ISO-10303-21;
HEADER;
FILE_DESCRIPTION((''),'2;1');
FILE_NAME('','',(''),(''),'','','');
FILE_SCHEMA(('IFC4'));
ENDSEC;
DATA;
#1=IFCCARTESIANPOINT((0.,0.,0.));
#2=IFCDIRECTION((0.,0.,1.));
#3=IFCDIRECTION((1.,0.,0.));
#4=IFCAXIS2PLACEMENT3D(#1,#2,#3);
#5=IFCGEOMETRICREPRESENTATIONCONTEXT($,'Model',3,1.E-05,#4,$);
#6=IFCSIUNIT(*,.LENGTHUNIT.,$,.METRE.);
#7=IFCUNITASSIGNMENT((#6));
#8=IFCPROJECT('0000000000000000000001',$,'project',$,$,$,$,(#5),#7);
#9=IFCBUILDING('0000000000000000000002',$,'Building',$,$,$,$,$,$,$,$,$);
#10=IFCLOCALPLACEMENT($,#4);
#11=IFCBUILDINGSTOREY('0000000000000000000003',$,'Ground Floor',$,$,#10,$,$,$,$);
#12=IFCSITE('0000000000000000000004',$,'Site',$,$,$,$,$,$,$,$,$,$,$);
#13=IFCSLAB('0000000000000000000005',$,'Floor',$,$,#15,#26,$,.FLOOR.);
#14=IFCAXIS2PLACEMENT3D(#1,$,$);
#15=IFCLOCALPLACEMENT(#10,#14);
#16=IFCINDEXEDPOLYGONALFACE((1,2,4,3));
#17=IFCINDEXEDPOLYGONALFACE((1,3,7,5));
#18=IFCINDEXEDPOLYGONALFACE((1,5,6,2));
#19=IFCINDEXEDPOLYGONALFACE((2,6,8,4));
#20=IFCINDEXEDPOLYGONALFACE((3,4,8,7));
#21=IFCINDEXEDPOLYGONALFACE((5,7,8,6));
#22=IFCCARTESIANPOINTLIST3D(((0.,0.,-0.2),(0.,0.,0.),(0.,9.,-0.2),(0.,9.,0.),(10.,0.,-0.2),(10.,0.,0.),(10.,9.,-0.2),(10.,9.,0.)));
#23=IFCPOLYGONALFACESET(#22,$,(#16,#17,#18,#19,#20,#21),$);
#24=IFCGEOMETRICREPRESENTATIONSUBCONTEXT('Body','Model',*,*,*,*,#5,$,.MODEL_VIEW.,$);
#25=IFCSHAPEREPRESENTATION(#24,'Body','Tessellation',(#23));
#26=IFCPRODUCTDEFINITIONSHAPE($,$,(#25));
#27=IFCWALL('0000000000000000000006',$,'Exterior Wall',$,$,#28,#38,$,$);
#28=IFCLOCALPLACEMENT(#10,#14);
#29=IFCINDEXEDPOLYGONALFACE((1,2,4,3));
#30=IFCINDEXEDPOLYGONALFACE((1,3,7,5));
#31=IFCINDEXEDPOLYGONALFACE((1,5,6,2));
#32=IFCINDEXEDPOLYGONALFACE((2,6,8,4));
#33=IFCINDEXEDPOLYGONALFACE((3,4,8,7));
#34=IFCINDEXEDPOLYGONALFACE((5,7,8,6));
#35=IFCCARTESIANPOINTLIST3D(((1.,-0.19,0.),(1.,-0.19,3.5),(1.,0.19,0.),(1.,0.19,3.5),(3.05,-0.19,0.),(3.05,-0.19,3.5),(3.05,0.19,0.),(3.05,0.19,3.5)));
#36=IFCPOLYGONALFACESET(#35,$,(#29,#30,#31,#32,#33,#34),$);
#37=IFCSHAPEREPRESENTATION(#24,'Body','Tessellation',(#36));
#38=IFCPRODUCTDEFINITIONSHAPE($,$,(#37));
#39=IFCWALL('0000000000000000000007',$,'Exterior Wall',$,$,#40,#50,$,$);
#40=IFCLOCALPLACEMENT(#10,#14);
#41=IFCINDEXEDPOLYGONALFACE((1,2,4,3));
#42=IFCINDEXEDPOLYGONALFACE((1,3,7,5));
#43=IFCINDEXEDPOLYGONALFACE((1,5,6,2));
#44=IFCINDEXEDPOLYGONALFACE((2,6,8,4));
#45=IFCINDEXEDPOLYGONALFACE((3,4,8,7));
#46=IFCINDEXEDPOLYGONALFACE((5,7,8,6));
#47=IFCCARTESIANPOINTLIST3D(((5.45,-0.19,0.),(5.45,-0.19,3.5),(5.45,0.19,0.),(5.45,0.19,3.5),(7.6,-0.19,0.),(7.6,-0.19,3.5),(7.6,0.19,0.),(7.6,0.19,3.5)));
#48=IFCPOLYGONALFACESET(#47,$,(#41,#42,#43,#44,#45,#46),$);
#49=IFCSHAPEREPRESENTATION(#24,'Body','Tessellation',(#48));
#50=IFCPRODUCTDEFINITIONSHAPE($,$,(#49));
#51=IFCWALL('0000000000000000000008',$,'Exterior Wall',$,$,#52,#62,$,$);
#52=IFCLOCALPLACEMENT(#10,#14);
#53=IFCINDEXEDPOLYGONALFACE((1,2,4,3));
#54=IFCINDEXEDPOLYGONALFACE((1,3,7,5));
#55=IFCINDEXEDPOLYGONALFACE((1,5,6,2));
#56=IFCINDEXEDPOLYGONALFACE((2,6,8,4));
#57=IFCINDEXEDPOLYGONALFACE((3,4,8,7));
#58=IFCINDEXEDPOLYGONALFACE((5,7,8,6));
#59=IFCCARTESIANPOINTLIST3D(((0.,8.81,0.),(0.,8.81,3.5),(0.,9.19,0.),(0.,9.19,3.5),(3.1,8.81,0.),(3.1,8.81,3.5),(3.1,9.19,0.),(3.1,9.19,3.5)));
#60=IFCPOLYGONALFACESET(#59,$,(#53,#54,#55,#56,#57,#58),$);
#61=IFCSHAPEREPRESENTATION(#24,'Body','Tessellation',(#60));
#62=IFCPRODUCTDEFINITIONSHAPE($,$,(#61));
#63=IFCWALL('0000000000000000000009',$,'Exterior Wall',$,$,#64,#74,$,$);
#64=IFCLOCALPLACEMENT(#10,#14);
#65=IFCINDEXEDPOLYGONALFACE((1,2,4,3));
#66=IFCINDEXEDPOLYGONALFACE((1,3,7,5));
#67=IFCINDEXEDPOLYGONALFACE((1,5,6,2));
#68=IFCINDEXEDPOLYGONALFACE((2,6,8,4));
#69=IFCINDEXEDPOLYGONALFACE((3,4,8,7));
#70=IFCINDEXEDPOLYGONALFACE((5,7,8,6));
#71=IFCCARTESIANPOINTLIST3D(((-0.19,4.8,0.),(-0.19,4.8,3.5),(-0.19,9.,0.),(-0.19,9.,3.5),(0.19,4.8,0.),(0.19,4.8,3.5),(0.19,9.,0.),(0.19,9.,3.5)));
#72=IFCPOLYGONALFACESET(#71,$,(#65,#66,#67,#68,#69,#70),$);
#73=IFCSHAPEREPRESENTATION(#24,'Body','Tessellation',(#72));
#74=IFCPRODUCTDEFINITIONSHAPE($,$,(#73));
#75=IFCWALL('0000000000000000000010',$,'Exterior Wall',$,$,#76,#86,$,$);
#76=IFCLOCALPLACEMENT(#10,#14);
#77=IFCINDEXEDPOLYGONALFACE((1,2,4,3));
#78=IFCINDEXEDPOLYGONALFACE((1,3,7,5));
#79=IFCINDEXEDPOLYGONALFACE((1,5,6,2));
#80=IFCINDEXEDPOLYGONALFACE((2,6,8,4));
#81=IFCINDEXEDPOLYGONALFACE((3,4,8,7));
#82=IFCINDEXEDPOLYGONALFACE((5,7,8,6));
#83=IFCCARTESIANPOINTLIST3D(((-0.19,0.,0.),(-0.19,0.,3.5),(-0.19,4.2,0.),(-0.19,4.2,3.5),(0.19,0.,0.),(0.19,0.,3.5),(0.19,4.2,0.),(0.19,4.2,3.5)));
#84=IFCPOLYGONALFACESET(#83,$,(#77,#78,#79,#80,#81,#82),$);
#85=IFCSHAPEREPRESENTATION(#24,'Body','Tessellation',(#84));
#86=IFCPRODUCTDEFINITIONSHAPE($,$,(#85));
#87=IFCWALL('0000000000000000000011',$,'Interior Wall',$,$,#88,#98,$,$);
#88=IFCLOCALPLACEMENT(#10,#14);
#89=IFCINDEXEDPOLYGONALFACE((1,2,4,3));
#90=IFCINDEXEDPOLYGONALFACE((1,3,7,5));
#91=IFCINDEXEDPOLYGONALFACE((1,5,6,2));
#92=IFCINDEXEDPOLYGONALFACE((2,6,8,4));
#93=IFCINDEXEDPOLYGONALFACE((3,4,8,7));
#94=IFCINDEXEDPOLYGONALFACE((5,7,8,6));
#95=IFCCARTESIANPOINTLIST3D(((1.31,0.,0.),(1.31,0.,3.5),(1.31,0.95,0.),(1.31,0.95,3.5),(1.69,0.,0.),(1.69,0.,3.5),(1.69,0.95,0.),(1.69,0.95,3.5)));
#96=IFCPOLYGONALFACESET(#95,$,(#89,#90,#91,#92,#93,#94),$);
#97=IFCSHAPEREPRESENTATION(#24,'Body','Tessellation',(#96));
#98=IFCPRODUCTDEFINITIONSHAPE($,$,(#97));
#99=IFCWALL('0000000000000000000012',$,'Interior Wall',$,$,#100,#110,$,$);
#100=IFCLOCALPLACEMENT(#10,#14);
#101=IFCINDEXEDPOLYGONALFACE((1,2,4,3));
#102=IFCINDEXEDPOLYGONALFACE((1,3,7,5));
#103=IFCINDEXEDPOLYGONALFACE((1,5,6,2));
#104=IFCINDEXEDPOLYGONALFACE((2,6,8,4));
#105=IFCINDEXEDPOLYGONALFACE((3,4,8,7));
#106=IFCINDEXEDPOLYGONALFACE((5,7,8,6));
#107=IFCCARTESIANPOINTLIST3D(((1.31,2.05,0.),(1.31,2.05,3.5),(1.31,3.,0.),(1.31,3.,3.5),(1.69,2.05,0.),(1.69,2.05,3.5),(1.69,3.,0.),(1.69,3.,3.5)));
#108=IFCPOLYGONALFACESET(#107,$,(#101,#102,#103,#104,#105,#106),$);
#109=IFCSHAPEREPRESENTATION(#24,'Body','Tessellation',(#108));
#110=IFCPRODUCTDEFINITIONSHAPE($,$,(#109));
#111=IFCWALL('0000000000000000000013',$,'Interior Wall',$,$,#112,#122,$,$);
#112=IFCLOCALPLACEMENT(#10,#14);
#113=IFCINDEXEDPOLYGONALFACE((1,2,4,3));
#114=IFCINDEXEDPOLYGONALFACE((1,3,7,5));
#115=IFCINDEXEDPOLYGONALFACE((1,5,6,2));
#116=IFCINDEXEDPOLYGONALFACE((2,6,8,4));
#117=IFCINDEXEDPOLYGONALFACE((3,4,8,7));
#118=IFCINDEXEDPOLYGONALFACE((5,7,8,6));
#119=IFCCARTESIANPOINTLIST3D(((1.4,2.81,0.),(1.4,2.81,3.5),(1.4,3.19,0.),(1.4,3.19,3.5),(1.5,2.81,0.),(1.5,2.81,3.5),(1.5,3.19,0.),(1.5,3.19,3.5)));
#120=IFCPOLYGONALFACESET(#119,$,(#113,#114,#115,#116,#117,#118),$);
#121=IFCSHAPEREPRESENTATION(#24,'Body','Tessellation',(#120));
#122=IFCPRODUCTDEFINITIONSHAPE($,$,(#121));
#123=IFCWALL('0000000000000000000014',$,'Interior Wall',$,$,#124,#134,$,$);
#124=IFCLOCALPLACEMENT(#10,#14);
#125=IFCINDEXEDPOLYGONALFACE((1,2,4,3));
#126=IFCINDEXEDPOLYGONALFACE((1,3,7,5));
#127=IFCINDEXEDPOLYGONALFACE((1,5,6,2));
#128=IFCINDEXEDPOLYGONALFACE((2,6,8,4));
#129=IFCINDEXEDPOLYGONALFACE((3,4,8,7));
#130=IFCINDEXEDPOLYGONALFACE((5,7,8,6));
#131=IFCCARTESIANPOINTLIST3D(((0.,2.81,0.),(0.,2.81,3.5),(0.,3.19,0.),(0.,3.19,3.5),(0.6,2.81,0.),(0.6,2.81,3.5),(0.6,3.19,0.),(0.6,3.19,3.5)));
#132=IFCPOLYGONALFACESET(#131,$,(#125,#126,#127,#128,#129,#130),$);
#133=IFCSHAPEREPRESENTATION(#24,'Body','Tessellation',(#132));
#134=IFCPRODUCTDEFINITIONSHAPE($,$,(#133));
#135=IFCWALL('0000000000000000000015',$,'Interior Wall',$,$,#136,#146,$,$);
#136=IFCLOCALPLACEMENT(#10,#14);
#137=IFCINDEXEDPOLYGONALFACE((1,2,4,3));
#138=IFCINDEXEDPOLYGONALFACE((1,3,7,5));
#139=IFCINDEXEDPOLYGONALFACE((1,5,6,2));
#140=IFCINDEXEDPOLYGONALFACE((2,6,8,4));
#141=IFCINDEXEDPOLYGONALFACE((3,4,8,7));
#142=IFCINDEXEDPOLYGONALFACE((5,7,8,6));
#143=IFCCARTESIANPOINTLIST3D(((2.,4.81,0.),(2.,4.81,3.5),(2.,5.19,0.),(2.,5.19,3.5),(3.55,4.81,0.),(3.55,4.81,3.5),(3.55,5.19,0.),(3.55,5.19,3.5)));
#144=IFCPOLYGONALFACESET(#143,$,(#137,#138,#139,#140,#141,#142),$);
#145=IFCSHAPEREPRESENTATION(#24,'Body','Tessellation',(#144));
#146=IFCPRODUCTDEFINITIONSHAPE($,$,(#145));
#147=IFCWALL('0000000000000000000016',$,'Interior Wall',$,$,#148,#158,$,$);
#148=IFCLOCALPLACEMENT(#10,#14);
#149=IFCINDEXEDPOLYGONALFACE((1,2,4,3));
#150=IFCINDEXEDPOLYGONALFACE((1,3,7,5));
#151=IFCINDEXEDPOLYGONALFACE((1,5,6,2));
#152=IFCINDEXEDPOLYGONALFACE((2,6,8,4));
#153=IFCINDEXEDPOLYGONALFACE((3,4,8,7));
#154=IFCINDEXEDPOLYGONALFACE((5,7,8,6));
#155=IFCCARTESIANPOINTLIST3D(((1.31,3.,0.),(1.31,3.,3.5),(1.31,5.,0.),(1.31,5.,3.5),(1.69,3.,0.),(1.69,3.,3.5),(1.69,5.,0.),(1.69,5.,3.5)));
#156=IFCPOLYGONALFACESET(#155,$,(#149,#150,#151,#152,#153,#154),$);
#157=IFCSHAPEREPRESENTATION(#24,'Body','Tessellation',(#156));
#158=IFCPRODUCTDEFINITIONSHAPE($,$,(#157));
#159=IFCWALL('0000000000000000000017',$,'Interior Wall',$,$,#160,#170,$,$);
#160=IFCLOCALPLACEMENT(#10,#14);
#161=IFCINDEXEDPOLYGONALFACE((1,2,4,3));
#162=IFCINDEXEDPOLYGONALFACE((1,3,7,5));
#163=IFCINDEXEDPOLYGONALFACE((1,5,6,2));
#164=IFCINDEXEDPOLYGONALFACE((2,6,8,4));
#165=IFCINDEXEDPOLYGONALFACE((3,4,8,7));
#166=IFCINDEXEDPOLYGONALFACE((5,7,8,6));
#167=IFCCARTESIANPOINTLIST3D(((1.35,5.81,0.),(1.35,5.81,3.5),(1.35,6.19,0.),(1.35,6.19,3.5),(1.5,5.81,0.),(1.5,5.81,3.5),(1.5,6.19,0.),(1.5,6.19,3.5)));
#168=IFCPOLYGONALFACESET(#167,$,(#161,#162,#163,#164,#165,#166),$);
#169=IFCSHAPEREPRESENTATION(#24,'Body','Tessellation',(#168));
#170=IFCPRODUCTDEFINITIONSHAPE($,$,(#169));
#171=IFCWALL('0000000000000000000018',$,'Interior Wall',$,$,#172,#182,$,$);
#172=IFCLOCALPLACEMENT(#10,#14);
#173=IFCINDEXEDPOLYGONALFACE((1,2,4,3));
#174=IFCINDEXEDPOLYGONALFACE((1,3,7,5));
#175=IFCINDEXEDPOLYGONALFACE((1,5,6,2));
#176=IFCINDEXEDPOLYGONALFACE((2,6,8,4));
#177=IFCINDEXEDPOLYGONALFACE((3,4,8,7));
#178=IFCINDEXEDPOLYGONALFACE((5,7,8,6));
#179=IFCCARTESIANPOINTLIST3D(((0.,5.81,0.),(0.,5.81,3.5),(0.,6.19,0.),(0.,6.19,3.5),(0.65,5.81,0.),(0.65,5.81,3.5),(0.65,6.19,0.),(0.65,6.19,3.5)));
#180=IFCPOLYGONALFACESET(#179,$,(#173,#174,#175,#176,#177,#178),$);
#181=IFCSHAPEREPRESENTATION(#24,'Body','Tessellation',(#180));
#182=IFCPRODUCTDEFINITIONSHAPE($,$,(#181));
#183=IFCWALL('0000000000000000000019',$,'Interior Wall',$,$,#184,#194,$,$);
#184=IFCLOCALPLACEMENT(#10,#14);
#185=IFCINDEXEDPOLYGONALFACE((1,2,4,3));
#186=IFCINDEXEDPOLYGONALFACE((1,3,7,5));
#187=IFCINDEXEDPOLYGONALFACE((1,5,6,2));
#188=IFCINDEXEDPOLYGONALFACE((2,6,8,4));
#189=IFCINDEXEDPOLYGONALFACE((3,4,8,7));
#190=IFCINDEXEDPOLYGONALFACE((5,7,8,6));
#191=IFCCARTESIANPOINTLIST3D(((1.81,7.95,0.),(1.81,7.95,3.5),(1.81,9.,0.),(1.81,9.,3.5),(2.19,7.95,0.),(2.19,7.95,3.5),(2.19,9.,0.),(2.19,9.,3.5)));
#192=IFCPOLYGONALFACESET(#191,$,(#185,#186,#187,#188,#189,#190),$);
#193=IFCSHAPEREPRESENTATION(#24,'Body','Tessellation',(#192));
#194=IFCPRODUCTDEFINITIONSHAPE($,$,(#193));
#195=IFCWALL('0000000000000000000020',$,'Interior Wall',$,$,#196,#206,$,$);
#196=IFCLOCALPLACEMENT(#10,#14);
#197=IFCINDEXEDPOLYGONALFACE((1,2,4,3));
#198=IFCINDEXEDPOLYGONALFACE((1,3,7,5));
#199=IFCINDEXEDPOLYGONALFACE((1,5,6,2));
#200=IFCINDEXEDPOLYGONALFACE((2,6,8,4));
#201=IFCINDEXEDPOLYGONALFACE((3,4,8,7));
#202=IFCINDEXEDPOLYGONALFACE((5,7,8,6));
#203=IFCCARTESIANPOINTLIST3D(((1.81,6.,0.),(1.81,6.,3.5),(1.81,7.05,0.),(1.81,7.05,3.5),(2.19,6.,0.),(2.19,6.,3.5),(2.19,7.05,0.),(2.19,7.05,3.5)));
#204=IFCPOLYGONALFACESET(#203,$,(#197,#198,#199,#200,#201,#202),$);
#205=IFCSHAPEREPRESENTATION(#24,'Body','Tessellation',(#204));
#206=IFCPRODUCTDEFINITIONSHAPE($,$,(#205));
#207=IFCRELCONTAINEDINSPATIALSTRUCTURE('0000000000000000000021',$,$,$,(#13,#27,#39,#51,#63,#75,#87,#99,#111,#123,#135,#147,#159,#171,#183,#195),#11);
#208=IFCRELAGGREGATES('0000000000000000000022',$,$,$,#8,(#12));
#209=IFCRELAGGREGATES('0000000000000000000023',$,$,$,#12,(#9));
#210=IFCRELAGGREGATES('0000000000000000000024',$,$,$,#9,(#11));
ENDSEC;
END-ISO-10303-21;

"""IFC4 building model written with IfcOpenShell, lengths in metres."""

from ifc_helpers import new_model, si_unit, frame, origin_with_axes, place, context, subcontext, project, spatial, indexed_curve, outline, extrude, element, save


model = new_model("IFC4")

# Units and contexts
model_context = context("Model", 3, precision=1e-05, world=origin_with_axes())
body_context = subcontext(model_context, "Body", "Model", "MODEL_VIEW")
ifc_project = project(units=[si_unit("LENGTHUNIT", "METRE")], contexts=[model_context])

# Site, building, storey
site = spatial("IfcSite", under=ifc_project, Name="Site")
building = spatial("IfcBuilding", under=site, Name="Building")
storey_placement = place(None, origin_with_axes())
storey = spatial("IfcBuildingStorey", under=building, at=storey_placement, Name="Ground Floor")

# Slab
slab_placement = place(storey_placement, frame((0.0, 0.0, -0.2), z_axis=(0.0, 0.0, 1.0), x_axis=(1.0, 0.0, 0.0)))
element("IfcSlab", 1, at=slab_placement, inside=storey, Name="Floor", PredefinedType="FLOOR", context=body_context, shape_type="SweptSolid", body=[
    extrude(outline(indexed_curve([(0.0, 0.0), (10.0, 0.0), (10.0, 9.0), (0.0, 9.0)])), None, (0.0, 0.0, 1.0), 0.2),
])

# Walls
wall_1_placement = place(storey_placement, frame((1.0, 0.0, 0.0), z_axis=(0.0, 0.0, 1.0), x_axis=(1.0, 0.0, 0.0)))
element("IfcWall", 2, at=wall_1_placement, inside=storey, Name="Exterior Wall", context=body_context, shape_type="SweptSolid", body=[
    extrude(outline(indexed_curve([(0.0, 0.0), (0.0, 0.38), (2.05, 0.38), (2.05, 0.0), (0.0, 0.0)], self_intersect=False)), frame((0.0, -0.19, 0.0), z_axis=(0.0, 0.0, 1.0), x_axis=(1.0, 0.0, 0.0)), (0.0, 0.0, 1.0), 3.5),
])
wall_2_placement = place(storey_placement, frame((5.45, 0.0, 0.0), z_axis=(0.0, 0.0, 1.0), x_axis=(1.0, 0.0, 0.0)))
element("IfcWall", 3, at=wall_2_placement, inside=storey, Name="Exterior Wall", context=body_context, shape_type="SweptSolid", body=[
    extrude(outline(indexed_curve([(0.0, 0.0), (0.0, 0.38), (2.15, 0.38), (2.15, 0.0), (0.0, 0.0)], self_intersect=False)), frame((0.0, -0.19, 0.0), z_axis=(0.0, 0.0, 1.0), x_axis=(1.0, 0.0, 0.0)), (0.0, 0.0, 1.0), 3.5),
])
wall_3_placement = place(storey_placement, frame((3.1, 9.0, 0.0), z_axis=(0.0, 0.0, 1.0), x_axis=(-1.0, 0.0, 0.0)))
element("IfcWall", 4, at=wall_3_placement, inside=storey, Name="Exterior Wall", context=body_context, shape_type="SweptSolid", body=[
    extrude(outline(indexed_curve([(0.0, 0.0), (0.0, 0.38), (3.1, 0.38), (3.1, 0.0), (0.0, 0.0)], self_intersect=False)), frame((0.0, -0.19, 0.0), z_axis=(0.0, 0.0, 1.0), x_axis=(1.0, 0.0, 0.0)), (0.0, 0.0, 1.0), 3.5),
])
for number, where, z_axis, x_axis, name in (
    (5, (0.0, 9.0, 0.0), (0.0, 0.0, 1.0), (0.0, -1.0, 0.0), "Exterior Wall"),
    (6, (0.0, 4.2, 0.0), (0.0, 0.0, 1.0), (0.0, -1.0, 0.0), "Exterior Wall"),
):
    element("IfcWall", number, at=place(storey_placement, frame(where, z_axis=z_axis, x_axis=x_axis)), inside=storey, Name=name, context=body_context, shape_type="SweptSolid", body=[
        extrude(outline(indexed_curve([(0.0, 0.0), (0.0, 0.38), (4.2, 0.38), (4.2, 0.0), (0.0, 0.0)], self_intersect=False)), frame((0.0, -0.19, 0.0), z_axis=(0.0, 0.0, 1.0), x_axis=(1.0, 0.0, 0.0)), (0.0, 0.0, 1.0), 3.5),
    ])
wall_4_placement = place(storey_placement, frame((1.5, 0.0, 0.0), z_axis=(0.0, 0.0, 1.0), x_axis=(0.0, 1.0, 0.0)))
element("IfcWall", 7, at=wall_4_placement, inside=storey, Name="Interior Wall", context=body_context, shape_type="SweptSolid", body=[
    extrude(outline(indexed_curve([(0.0, 0.0), (0.0, 0.38), (0.95, 0.38), (0.95, 0.0), (0.0, 0.0)], self_intersect=False)), frame((0.0, -0.19, 0.0), z_axis=(0.0, 0.0, 1.0), x_axis=(1.0, 0.0, 0.0)), (0.0, 0.0, 1.0), 3.5),
])
wall_5_placement = place(storey_placement, frame((1.5, 2.05, 0.0), z_axis=(0.0, 0.0, 1.0), x_axis=(0.0, 1.0, 0.0)))
element("IfcWall", 8, at=wall_5_placement, inside=storey, Name="Interior Wall", context=body_context, shape_type="SweptSolid", body=[
    extrude(outline(indexed_curve([(0.0, 0.0), (0.0, 0.38), (0.95, 0.38), (0.95, 0.0), (0.0, 0.0)], self_intersect=False)), frame((0.0, -0.19, 0.0), z_axis=(0.0, 0.0, 1.0), x_axis=(1.0, 0.0, 0.0)), (0.0, 0.0, 1.0), 3.5),
])
wall_6_placement = place(storey_placement, frame((1.5, 3.0, 0.0), z_axis=(0.0, 0.0, 1.0), x_axis=(-1.0, 0.0, 0.0)))
element("IfcWall", 9, at=wall_6_placement, inside=storey, Name="Interior Wall", context=body_context, shape_type="SweptSolid", body=[
    extrude(outline(indexed_curve([(0.0, 0.0), (0.0, 0.38), (0.1, 0.38), (0.1, 0.0), (0.0, 0.0)], self_intersect=False)), frame((0.0, -0.19, 0.0), z_axis=(0.0, 0.0, 1.0), x_axis=(1.0, 0.0, 0.0)), (0.0, 0.0, 1.0), 3.5),
])
wall_7_placement = place(storey_placement, frame((0.6, 3.0, 0.0), z_axis=(0.0, 0.0, 1.0), x_axis=(-1.0, 0.0, 0.0)))
element("IfcWall", 10, at=wall_7_placement, inside=storey, Name="Interior Wall", context=body_context, shape_type="SweptSolid", body=[
    extrude(outline(indexed_curve([(0.0, 0.0), (0.0, 0.38), (0.6, 0.38), (0.6, 0.0), (0.0, 0.0)], self_intersect=False)), frame((0.0, -0.19, 0.0), z_axis=(0.0, 0.0, 1.0), x_axis=(1.0, 0.0, 0.0)), (0.0, 0.0, 1.0), 3.5),
])
wall_8_placement = place(storey_placement, frame((3.55, 5.0, 0.0), z_axis=(0.0, 0.0, 1.0), x_axis=(-1.0, 0.0, 0.0)))
element("IfcWall", 11, at=wall_8_placement, inside=storey, Name="Interior Wall", context=body_context, shape_type="SweptSolid", body=[
    extrude(outline(indexed_curve([(0.0, 0.0), (0.0, 0.38), (1.55, 0.38), (1.55, 0.0), (0.0, 0.0)], self_intersect=False)), frame((0.0, -0.19, 0.0), z_axis=(0.0, 0.0, 1.0), x_axis=(1.0, 0.0, 0.0)), (0.0, 0.0, 1.0), 3.5),
])
wall_9_placement = place(storey_placement, frame((1.5, 5.0, 0.0), z_axis=(0.0, 0.0, 1.0), x_axis=(0.0, -1.0, 0.0)))
element("IfcWall", 12, at=wall_9_placement, inside=storey, Name="Interior Wall", context=body_context, shape_type="SweptSolid", body=[
    extrude(outline(indexed_curve([(0.0, 0.0), (0.0, 0.38), (2.0, 0.38), (2.0, 0.0), (0.0, 0.0)], self_intersect=False)), frame((0.0, -0.19, 0.0), z_axis=(0.0, 0.0, 1.0), x_axis=(1.0, 0.0, 0.0)), (0.0, 0.0, 1.0), 3.5),
])
wall_10_placement = place(storey_placement, frame((1.5, 6.0, 0.0), z_axis=(0.0, 0.0, 1.0), x_axis=(-1.0, 0.0, 0.0)))
element("IfcWall", 13, at=wall_10_placement, inside=storey, Name="Interior Wall", context=body_context, shape_type="SweptSolid", body=[
    extrude(outline(indexed_curve([(0.0, 0.0), (0.0, 0.38), (0.15, 0.38), (0.15, 0.0), (0.0, 0.0)], self_intersect=False)), frame((0.0, -0.19, 0.0), z_axis=(0.0, 0.0, 1.0), x_axis=(1.0, 0.0, 0.0)), (0.0, 0.0, 1.0), 3.5),
])
wall_11_placement = place(storey_placement, frame((0.65, 6.0, 0.0), z_axis=(0.0, 0.0, 1.0), x_axis=(-1.0, 0.0, 0.0)))
element("IfcWall", 14, at=wall_11_placement, inside=storey, Name="Interior Wall", context=body_context, shape_type="SweptSolid", body=[
    extrude(outline(indexed_curve([(0.0, 0.0), (0.0, 0.38), (0.65, 0.38), (0.65, 0.0), (0.0, 0.0)], self_intersect=False)), frame((0.0, -0.19, 0.0), z_axis=(0.0, 0.0, 1.0), x_axis=(1.0, 0.0, 0.0)), (0.0, 0.0, 1.0), 3.5),
])
for number, where, z_axis, x_axis, name in (
    (15, (2.0, 9.0, 0.0), (0.0, 0.0, 1.0), (0.0, -1.0, 0.0), "Interior Wall"),
    (16, (2.0, 7.05, 0.0), (0.0, 0.0, 1.0), (0.0, -1.0, 0.0), "Interior Wall"),
):
    element("IfcWall", number, at=place(storey_placement, frame(where, z_axis=z_axis, x_axis=x_axis)), inside=storey, Name=name, context=body_context, shape_type="SweptSolid", body=[
        extrude(outline(indexed_curve([(0.0, 0.0), (0.0, 0.38), (1.05, 0.38), (1.05, 0.0), (0.0, 0.0)], self_intersect=False)), frame((0.0, -0.19, 0.0), z_axis=(0.0, 0.0, 1.0), x_axis=(1.0, 0.0, 0.0)), (0.0, 0.0, 1.0), 3.5),
    ])

save(model, "model.ifc")
